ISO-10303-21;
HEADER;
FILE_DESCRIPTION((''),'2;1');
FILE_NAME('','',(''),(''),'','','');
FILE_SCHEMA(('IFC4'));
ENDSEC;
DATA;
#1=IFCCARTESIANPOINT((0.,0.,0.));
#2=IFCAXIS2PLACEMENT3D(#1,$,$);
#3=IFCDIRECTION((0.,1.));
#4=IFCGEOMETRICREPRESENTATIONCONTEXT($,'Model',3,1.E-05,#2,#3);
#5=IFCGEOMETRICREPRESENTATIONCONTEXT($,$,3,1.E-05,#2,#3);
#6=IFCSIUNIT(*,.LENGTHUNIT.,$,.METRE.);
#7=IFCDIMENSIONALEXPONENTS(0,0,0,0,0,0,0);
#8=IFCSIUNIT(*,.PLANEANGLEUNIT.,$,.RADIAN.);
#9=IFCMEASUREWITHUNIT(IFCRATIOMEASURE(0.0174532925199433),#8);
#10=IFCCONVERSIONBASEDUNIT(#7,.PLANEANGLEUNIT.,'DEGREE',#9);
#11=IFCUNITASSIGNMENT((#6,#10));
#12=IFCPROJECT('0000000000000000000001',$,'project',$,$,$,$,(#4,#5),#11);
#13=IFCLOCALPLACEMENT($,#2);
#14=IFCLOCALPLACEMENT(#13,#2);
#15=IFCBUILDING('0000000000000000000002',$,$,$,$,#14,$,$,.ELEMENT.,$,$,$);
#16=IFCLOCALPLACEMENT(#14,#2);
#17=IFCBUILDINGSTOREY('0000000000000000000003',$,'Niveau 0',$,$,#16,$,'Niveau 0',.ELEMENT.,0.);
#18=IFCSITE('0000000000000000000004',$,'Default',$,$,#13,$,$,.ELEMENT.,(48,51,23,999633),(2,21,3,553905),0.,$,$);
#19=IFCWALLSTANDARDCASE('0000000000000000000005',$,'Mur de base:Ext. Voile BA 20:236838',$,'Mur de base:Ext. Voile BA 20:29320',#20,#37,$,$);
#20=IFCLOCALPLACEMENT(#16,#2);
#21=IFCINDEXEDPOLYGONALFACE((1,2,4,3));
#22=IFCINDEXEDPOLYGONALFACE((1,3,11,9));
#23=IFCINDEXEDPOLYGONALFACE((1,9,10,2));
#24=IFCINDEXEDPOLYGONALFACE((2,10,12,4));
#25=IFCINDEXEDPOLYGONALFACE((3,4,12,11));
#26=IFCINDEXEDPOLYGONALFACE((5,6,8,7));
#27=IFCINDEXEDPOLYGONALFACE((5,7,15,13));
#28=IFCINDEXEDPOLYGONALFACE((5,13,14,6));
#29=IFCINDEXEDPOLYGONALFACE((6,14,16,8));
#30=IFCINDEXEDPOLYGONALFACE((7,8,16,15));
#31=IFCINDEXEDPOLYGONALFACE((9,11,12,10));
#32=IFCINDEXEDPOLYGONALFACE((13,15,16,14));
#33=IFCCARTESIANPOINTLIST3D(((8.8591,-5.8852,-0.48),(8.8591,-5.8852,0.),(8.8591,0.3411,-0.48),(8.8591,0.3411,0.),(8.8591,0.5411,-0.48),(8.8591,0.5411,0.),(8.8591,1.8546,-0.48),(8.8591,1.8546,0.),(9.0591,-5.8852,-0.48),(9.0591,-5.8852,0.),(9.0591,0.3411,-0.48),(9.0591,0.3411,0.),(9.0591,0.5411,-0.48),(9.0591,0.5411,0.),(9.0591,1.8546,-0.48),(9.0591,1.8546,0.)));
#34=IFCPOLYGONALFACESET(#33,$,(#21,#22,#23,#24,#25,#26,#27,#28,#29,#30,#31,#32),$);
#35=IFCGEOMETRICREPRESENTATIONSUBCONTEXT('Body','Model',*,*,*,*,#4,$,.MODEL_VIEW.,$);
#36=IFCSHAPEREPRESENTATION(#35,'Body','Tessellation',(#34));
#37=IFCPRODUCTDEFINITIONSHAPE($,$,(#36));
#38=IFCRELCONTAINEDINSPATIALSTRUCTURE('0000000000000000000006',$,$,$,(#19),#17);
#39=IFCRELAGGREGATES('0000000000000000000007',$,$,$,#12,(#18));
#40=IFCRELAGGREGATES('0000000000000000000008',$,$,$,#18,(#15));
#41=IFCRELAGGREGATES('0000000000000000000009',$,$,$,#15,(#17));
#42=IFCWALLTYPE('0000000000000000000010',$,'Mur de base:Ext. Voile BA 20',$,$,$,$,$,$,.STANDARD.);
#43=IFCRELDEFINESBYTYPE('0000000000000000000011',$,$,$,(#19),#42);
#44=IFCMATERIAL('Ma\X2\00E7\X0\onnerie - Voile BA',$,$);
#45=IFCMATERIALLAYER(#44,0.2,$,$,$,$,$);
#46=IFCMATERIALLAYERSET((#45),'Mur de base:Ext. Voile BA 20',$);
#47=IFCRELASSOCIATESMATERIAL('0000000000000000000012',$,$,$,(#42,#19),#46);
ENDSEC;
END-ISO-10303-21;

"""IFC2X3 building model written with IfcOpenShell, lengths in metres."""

from ifc_helpers import new_model, entity, si_unit, converted_unit, direction, frame, frame_2d, origin, origin_2d_with_axis, place, context, subcontext, project, spatial, rectangle, extrude, material, layer, layer_set, layer_usage, type_object, element, save


model = new_model("IFC2X3")

# Units and contexts
model_context = context("Model", 3, precision=1e-05, world=origin(), true_north=direction((0.0, 1.0)))
context_of_model = context(None, 3, precision=1e-05, world=origin(), true_north=direction((0.0, 1.0)))
body_context = subcontext(model_context, "Body", "Model", "MODEL_VIEW")
ifc_project = project(units=[si_unit("LENGTHUNIT", "METRE"), converted_unit("PLANEANGLEUNIT", "DEGREE", entity("IfcRatioMeasure", 0.0174532925199433), si_unit("PLANEANGLEUNIT", "RADIAN"), dimensions=[0, 0, 0, 0, 0, 0, 0])], contexts=[model_context, context_of_model])

# Site, building, storey
site_placement = place(None, origin())
site = spatial("IfcSite", under=ifc_project, at=site_placement, Name="Default", CompositionType="ELEMENT", RefLatitude=(48, 51, 23, 999633), RefLongitude=(2, 21, 3, 553905), RefElevation=0.0)
building_placement = place(site_placement, origin())
building = spatial("IfcBuilding", under=site, at=building_placement, CompositionType="ELEMENT")
storey_placement = place(building_placement, origin())
storey = spatial("IfcBuildingStorey", under=building, at=storey_placement, Name="Niveau 0", LongName="Niveau 0", CompositionType="ELEMENT", Elevation=0.0)

# Shared definitions
ifc_material_1 = material(Name="Maçonnerie - Voile BA")
ifc_layer_1 = layer(ifc_material_1, 0.2)
ifc_layer_set_1 = layer_set([ifc_layer_1], Name="Mur de base:Ext. Voile BA 20")
wall_type = type_object("IfcWallType", Name="Mur de base:Ext. Voile BA 20", PredefinedType="STANDARD", material=ifc_layer_set_1)

# Wall, opening
ifc_layer_usage_1 = layer_usage(ifc_layer_set_1, "AXIS2", "NEGATIVE", 0.1)
wall_1_placement = place(storey_placement, frame((8.9591, 1.8546, -0.48), z_axis=(0.0, 0.0, 1.0), x_axis=(0.0, -1.0, 0.0)))
wall_1 = element("IfcWallStandardCase", 1, at=wall_1_placement, inside=storey, type_object=wall_type, material=ifc_layer_usage_1, Name="Mur de base:Ext. Voile BA 20:236838", ObjectType="Mur de base:Ext. Voile BA 20:29320", context=body_context, shape_type="SweptSolid", body=[
    extrude(rectangle(XDim=7.7398, YDim=0.2, at=frame_2d((3.8699, 0.0), x_axis=(-1.0, 0.0))), origin(), (0.0, 0.0, 1.0), 0.48),
])
opening_1_placement = place(storey_placement, frame((8.9591, 1.8546, -0.48), z_axis=(0.0, 0.0, 1.0), x_axis=(0.0, -1.0, 0.0)))
element("IfcOpeningElement", 2, at=opening_1_placement, cuts=wall_1, ObjectType="Opening", context=body_context, shape_type="SweptSolid", body=[
    extrude(rectangle(XDim=0.48, YDim=0.2, at=origin_2d_with_axis()), frame((1.5135, 0.0, 0.24), z_axis=(-1.0, 0.0, 0.0), x_axis=(0.0, 0.0, 1.0)), (0.0, 0.0, 1.0), 0.2),
])

save(model, "model.ifc")
